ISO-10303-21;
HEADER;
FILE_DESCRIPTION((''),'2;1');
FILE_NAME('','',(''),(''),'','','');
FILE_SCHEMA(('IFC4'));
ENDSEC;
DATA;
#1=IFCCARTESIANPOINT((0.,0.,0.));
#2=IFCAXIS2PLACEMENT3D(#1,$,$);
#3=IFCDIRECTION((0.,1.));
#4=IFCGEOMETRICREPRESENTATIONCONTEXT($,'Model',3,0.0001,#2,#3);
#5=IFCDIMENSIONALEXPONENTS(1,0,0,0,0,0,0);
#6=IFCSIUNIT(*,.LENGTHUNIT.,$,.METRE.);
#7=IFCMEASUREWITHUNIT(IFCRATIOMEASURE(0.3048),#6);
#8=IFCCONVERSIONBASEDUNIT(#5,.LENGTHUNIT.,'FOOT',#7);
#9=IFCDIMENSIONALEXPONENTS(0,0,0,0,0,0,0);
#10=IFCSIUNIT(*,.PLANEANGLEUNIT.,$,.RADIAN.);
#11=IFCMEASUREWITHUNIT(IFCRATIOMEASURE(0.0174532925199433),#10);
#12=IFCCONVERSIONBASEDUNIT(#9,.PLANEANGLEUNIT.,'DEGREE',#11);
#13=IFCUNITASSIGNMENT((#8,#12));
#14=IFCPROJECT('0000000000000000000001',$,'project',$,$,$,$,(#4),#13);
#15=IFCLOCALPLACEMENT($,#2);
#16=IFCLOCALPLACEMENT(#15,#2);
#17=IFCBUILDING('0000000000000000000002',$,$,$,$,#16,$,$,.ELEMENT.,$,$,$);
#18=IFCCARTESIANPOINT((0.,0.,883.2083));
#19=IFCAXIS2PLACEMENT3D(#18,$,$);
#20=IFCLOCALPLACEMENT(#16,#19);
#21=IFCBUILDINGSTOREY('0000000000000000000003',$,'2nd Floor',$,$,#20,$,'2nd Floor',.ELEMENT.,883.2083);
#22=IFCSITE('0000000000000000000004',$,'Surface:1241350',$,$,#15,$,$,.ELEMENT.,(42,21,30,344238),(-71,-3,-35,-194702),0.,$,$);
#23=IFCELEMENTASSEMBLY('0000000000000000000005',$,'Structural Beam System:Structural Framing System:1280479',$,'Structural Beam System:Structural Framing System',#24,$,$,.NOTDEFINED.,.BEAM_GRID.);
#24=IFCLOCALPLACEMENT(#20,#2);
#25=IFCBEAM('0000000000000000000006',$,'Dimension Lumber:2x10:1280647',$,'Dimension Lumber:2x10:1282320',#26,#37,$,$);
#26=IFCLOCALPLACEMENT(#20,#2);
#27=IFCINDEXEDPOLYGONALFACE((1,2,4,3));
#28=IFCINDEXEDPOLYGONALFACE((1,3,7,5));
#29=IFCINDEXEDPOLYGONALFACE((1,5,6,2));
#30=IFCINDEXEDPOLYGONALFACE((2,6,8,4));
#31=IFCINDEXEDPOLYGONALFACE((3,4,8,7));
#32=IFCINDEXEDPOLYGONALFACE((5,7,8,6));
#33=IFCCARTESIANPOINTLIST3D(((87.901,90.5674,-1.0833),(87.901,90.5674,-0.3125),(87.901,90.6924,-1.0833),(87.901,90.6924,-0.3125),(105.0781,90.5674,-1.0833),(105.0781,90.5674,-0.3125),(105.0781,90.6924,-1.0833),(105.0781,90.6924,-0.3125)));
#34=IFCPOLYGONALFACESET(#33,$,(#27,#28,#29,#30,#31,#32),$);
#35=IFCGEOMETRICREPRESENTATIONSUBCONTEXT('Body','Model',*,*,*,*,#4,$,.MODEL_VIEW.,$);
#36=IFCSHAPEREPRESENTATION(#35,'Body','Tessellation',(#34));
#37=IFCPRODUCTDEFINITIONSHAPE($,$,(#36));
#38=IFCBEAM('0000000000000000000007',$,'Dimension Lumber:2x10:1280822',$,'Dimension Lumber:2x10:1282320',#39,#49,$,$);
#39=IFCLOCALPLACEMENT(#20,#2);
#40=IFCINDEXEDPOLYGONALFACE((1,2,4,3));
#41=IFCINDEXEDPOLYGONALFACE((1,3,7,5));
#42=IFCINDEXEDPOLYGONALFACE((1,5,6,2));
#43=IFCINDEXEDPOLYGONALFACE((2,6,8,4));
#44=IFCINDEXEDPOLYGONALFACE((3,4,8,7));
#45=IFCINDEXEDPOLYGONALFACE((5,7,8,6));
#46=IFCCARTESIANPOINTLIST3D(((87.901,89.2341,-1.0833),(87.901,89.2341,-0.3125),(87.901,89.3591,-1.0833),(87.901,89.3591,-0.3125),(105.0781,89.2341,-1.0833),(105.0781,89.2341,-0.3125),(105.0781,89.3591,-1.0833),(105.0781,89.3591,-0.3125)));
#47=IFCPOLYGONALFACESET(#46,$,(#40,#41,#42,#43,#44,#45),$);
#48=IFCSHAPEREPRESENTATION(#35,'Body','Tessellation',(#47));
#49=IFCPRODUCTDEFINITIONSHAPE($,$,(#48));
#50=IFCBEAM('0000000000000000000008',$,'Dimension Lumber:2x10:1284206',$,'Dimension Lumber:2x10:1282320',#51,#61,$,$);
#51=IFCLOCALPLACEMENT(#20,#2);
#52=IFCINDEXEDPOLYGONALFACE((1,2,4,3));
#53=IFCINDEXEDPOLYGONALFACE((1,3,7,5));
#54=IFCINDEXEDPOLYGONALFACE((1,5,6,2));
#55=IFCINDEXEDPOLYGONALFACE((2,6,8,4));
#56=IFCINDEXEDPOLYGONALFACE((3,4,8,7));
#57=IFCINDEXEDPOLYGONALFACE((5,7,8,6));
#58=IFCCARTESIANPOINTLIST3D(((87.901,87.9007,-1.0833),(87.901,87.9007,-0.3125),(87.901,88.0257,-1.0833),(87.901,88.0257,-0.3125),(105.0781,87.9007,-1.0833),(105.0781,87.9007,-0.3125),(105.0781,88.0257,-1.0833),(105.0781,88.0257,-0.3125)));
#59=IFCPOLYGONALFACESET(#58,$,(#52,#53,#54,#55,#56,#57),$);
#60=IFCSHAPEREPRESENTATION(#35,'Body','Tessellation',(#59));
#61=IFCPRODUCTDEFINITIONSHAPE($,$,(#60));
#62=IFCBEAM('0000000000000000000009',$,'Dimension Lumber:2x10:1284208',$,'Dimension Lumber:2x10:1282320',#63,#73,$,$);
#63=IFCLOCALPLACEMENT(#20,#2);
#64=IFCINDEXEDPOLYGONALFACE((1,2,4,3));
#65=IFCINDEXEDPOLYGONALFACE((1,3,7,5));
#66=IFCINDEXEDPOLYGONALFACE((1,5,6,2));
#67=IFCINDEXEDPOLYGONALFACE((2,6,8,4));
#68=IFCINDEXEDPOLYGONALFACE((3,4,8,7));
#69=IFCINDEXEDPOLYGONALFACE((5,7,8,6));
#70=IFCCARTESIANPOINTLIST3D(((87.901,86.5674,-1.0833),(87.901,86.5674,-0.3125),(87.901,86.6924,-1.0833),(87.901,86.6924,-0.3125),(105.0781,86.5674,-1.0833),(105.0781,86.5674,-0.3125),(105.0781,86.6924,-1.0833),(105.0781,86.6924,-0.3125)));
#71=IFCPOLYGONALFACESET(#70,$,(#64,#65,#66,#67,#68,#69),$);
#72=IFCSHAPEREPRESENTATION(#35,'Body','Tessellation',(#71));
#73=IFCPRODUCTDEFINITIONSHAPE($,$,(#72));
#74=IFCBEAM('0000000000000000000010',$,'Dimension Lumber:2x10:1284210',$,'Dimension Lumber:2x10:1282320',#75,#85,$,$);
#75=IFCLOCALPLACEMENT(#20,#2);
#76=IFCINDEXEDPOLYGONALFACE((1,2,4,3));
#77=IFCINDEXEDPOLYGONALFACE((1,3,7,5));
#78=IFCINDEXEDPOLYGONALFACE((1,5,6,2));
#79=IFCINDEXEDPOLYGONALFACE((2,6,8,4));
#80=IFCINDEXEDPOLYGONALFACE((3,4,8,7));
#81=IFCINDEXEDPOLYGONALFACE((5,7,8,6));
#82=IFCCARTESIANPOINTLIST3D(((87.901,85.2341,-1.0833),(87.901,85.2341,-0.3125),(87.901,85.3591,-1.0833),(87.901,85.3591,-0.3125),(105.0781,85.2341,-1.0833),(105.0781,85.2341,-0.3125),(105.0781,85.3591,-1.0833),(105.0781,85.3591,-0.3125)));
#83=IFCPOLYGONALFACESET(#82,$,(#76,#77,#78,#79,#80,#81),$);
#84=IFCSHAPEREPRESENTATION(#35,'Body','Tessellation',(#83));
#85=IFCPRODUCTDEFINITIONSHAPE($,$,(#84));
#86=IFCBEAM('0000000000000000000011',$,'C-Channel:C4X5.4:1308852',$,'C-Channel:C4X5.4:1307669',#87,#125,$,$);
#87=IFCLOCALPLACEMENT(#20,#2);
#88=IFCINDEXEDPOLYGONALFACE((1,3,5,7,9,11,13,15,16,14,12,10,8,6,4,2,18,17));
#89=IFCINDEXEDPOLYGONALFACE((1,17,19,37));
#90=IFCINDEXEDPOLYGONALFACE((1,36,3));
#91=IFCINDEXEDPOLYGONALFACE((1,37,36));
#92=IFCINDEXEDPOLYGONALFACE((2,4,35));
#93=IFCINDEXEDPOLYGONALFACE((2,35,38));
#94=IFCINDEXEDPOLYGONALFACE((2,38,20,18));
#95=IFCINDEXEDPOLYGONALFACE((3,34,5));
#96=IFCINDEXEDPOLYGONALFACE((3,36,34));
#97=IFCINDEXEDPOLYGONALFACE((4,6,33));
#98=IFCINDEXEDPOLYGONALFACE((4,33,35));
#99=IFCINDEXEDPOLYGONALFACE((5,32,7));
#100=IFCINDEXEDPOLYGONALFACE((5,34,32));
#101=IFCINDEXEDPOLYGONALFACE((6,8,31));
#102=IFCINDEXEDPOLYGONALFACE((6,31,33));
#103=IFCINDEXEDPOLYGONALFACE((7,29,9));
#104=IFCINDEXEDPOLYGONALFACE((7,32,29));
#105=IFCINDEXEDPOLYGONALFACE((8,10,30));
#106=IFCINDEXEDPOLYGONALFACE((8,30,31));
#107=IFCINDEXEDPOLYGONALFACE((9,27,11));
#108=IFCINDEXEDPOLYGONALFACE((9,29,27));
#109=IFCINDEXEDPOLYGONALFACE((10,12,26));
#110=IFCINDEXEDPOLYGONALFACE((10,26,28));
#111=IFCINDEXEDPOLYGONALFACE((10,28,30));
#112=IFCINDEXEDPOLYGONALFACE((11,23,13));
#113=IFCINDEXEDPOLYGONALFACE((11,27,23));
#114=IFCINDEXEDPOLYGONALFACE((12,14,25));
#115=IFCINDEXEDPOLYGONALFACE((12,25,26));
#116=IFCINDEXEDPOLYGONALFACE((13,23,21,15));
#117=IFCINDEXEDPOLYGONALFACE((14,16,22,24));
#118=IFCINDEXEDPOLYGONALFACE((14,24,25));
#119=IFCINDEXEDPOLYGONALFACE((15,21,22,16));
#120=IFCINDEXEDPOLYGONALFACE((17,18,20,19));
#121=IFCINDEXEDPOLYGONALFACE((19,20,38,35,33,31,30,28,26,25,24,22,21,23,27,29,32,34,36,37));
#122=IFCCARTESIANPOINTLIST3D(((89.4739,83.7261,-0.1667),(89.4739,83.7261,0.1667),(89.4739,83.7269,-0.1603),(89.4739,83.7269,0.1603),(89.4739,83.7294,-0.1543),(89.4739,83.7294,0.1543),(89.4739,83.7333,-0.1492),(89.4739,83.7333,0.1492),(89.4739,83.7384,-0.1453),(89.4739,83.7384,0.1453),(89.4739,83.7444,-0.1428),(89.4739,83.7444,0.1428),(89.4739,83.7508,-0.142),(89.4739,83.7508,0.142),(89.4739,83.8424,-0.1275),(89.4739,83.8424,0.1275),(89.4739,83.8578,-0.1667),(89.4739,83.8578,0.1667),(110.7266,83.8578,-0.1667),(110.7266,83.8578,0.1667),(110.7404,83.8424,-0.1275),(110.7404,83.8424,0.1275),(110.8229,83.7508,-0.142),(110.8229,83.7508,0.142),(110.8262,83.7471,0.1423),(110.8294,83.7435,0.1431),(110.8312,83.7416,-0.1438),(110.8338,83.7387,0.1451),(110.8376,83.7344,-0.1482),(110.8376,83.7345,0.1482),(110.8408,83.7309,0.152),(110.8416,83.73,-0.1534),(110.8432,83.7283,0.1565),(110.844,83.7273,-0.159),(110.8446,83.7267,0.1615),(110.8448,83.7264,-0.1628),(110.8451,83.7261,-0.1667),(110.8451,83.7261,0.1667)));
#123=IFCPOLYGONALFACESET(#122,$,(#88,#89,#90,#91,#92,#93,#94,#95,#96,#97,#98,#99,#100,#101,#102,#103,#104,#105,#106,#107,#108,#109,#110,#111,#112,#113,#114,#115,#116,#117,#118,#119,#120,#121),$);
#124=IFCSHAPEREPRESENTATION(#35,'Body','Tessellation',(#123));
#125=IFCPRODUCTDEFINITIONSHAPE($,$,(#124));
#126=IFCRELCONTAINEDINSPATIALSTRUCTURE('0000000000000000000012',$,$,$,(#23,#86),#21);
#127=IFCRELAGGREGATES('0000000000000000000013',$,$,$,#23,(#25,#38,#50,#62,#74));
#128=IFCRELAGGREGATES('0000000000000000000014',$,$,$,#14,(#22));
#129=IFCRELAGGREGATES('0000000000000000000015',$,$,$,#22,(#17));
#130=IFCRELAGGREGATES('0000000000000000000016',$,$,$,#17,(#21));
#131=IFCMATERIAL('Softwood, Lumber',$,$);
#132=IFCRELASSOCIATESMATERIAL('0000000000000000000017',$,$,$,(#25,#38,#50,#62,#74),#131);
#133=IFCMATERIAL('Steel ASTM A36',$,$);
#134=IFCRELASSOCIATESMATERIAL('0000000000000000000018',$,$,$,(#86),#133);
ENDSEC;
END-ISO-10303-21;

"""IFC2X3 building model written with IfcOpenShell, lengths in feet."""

from ifc_helpers import new_model, entity, si_unit, converted_unit, direction, frame, frame_2d, origin, place, context, subcontext, project, spatial, polyline, circle_curve, parameter, trimmed, segment, composite_curve, rectangle, outline, extrude, clip, halfspace, material, element, aggregate, save


model = new_model("IFC2X3")

# Units and contexts
model_context = context("Model", 3, precision=0.0001, world=origin(), true_north=direction((0.0, 1.0)))
body_context = subcontext(model_context, "Body", "Model", "MODEL_VIEW")
ifc_project = project(units=[converted_unit("LENGTHUNIT", "FOOT", entity("IfcRatioMeasure", 0.3048), si_unit("LENGTHUNIT", "METRE"), dimensions=[1, 0, 0, 0, 0, 0, 0]), converted_unit("PLANEANGLEUNIT", "DEGREE", entity("IfcRatioMeasure", 0.0174532925199433), si_unit("PLANEANGLEUNIT", "RADIAN"), dimensions=[0, 0, 0, 0, 0, 0, 0])], contexts=[model_context])

# Site, building, storey
site_placement = place(None, origin())
site = spatial("IfcSite", under=ifc_project, at=site_placement, Name="Surface:1241350", CompositionType="ELEMENT", RefLatitude=(42, 21, 30, 344238), RefLongitude=(-71, -3, -35, -194702), RefElevation=0.0)
building_placement = place(site_placement, origin())
building = spatial("IfcBuilding", under=site, at=building_placement, CompositionType="ELEMENT")
storey_placement = place(building_placement, frame((0.0, 0.0, 883.2083)))
storey = spatial("IfcBuildingStorey", under=building, at=storey_placement, Name="2nd Floor", LongName="2nd Floor", CompositionType="ELEMENT", Elevation=883.2083)

# Element assembly, beams
assembly_1_placement = place(storey_placement, origin())
assembly_1 = element("IfcElementAssembly", 1, at=assembly_1_placement, inside=storey, Name="Structural Beam System:Structural Framing System:1280479", ObjectType="Structural Beam System:Structural Framing System", AssemblyPlace="NOTDEFINED", PredefinedType="BEAM_GRID")
ifc_material_1 = material(Name="Softwood, Lumber")
beam_1_placement = place(assembly_1_placement, frame((87.901, 90.6299, 0.0)))
beam_1 = element("IfcBeam", 2, at=beam_1_placement, material=ifc_material_1, Name="Dimension Lumber:2x10:1280647", ObjectType="Dimension Lumber:2x10:1282320", context=body_context, shape_type="SweptSolid", body=[
    extrude(rectangle(XDim=0.7708, YDim=0.125, at=frame_2d((0.0, 0.0), x_axis=(1.0, 0.0))), frame((0.0, 0.0, -0.6979), z_axis=(1.0, 0.0, 0.0), x_axis=(0.0, 0.0, -1.0)), (0.0, 0.0, 1.0), 17.1771),
])
beam_2_placement = place(assembly_1_placement, frame((87.901, 89.2966, 0.0)))
beam_2 = element("IfcBeam", 3, at=beam_2_placement, material=ifc_material_1, Name="Dimension Lumber:2x10:1280822", ObjectType="Dimension Lumber:2x10:1282320", context=body_context, shape_type="SweptSolid", body=[
    extrude(rectangle(XDim=0.7708, YDim=0.125, at=frame_2d((0.0, 0.0), x_axis=(1.0, 0.0))), frame((0.0, 0.0, -0.6979), z_axis=(1.0, 0.0, 0.0), x_axis=(0.0, 0.0, -1.0)), (0.0, 0.0, 1.0), 17.1771),
])

# Beams
beam_3_placement = place(assembly_1_placement, frame((87.901, 87.9632, 0.0)))
beam_3 = element("IfcBeam", 4, at=beam_3_placement, material=ifc_material_1, Name="Dimension Lumber:2x10:1284206", ObjectType="Dimension Lumber:2x10:1282320", context=body_context, shape_type="SweptSolid", body=[
    extrude(rectangle(XDim=0.7708, YDim=0.125, at=frame_2d((0.0, 0.0), x_axis=(1.0, 0.0))), frame((0.0, 0.0, -0.6979), z_axis=(1.0, 0.0, 0.0), x_axis=(0.0, 0.0, -1.0)), (0.0, 0.0, 1.0), 17.1771),
])
beam_4_placement = place(assembly_1_placement, frame((87.901, 86.6299, 0.0)))
beam_4 = element("IfcBeam", 5, at=beam_4_placement, material=ifc_material_1, Name="Dimension Lumber:2x10:1284208", ObjectType="Dimension Lumber:2x10:1282320", context=body_context, shape_type="SweptSolid", body=[
    extrude(rectangle(XDim=0.7708, YDim=0.125, at=frame_2d((0.0, 0.0), x_axis=(1.0, 0.0))), frame((0.0, 0.0, -0.6979), z_axis=(1.0, 0.0, 0.0), x_axis=(0.0, 0.0, -1.0)), (0.0, 0.0, 1.0), 17.1771),
])
beam_5_placement = place(assembly_1_placement, frame((87.901, 85.2966, 0.0)))
beam_5 = element("IfcBeam", 6, at=beam_5_placement, material=ifc_material_1, Name="Dimension Lumber:2x10:1284210", ObjectType="Dimension Lumber:2x10:1282320", context=body_context, shape_type="SweptSolid", body=[
    extrude(rectangle(XDim=0.7708, YDim=0.125, at=frame_2d((0.0, 0.0), x_axis=(1.0, 0.0))), frame((0.0, 0.0, -0.6979), z_axis=(1.0, 0.0, 0.0), x_axis=(0.0, 0.0, -1.0)), (0.0, 0.0, 1.0), 17.1771),
])
aggregate(assembly_1, [beam_1, beam_2, beam_3, beam_4, beam_5])

# Beam
ifc_material_2 = material(Name="Steel ASTM A36")
beam_6_placement = place(storey_placement, frame((110.7609, 83.8197, 0.0), z_axis=(0.0, 0.0, 1.0), x_axis=(-1.0, 0.0, 0.0)))
element("IfcBeam", 7, at=beam_6_placement, inside=storey, material=ifc_material_2, Name="C-Channel:C4X5.4:1308852", ObjectType="C-Channel:C4X5.4:1307669", context=body_context, shape_type="Clipping", body=[
    clip(extrude(outline(composite_curve([segment(polyline([(-0.1667, -0.0635), (0.1667, -0.0635)]), True, "CONTINUOUS"), segment(polyline([(0.1667, -0.0635), (0.1667, 0.0682)]), True, "CONTINUOUS"), segment(trimmed(circle_curve(frame_2d((0.1667, 0.0435), x_axis=(0.0, 1.0)), 0.0247), [parameter(0.0)], [parameter(90.0)], True, "PARAMETER"), True, "CONTINUOUS"), segment(polyline([(0.142, 0.0435), (0.1275, -0.0482)]), True, "CONTINUOUS"), segment(polyline([(0.1275, -0.0482), (-0.1275, -0.0482)]), True, "CONTINUOUS"), segment(polyline([(-0.1275, -0.0482), (-0.142, 0.0435)]), True, "CONTINUOUS"), segment(trimmed(circle_curve(frame_2d((-0.1667, 0.0435), x_axis=(1.0, 0.0)), 0.0247), [parameter(0.0)], [parameter(90.0)], True, "PARAMETER"), True, "CONTINUOUS"), segment(polyline([(-0.1667, 0.0682), (-0.1667, -0.0635)]), True, "CONTINUOUS")], self_intersect=False)), frame((-0.0843, 0.0254, 0.0), z_axis=(1.0, 0.0, 0.0), x_axis=(0.0, 0.0, -1.0)), (0.0, 0.0, 1.0), 21.3712), halfspace(frame((0.0343, -0.0381, 0.0), z_axis=(-0.743145, -0.669131, 0.0), x_axis=(-0.669131, 0.743145, 0.0)), False)),
])

save(model, "model.ifc")
